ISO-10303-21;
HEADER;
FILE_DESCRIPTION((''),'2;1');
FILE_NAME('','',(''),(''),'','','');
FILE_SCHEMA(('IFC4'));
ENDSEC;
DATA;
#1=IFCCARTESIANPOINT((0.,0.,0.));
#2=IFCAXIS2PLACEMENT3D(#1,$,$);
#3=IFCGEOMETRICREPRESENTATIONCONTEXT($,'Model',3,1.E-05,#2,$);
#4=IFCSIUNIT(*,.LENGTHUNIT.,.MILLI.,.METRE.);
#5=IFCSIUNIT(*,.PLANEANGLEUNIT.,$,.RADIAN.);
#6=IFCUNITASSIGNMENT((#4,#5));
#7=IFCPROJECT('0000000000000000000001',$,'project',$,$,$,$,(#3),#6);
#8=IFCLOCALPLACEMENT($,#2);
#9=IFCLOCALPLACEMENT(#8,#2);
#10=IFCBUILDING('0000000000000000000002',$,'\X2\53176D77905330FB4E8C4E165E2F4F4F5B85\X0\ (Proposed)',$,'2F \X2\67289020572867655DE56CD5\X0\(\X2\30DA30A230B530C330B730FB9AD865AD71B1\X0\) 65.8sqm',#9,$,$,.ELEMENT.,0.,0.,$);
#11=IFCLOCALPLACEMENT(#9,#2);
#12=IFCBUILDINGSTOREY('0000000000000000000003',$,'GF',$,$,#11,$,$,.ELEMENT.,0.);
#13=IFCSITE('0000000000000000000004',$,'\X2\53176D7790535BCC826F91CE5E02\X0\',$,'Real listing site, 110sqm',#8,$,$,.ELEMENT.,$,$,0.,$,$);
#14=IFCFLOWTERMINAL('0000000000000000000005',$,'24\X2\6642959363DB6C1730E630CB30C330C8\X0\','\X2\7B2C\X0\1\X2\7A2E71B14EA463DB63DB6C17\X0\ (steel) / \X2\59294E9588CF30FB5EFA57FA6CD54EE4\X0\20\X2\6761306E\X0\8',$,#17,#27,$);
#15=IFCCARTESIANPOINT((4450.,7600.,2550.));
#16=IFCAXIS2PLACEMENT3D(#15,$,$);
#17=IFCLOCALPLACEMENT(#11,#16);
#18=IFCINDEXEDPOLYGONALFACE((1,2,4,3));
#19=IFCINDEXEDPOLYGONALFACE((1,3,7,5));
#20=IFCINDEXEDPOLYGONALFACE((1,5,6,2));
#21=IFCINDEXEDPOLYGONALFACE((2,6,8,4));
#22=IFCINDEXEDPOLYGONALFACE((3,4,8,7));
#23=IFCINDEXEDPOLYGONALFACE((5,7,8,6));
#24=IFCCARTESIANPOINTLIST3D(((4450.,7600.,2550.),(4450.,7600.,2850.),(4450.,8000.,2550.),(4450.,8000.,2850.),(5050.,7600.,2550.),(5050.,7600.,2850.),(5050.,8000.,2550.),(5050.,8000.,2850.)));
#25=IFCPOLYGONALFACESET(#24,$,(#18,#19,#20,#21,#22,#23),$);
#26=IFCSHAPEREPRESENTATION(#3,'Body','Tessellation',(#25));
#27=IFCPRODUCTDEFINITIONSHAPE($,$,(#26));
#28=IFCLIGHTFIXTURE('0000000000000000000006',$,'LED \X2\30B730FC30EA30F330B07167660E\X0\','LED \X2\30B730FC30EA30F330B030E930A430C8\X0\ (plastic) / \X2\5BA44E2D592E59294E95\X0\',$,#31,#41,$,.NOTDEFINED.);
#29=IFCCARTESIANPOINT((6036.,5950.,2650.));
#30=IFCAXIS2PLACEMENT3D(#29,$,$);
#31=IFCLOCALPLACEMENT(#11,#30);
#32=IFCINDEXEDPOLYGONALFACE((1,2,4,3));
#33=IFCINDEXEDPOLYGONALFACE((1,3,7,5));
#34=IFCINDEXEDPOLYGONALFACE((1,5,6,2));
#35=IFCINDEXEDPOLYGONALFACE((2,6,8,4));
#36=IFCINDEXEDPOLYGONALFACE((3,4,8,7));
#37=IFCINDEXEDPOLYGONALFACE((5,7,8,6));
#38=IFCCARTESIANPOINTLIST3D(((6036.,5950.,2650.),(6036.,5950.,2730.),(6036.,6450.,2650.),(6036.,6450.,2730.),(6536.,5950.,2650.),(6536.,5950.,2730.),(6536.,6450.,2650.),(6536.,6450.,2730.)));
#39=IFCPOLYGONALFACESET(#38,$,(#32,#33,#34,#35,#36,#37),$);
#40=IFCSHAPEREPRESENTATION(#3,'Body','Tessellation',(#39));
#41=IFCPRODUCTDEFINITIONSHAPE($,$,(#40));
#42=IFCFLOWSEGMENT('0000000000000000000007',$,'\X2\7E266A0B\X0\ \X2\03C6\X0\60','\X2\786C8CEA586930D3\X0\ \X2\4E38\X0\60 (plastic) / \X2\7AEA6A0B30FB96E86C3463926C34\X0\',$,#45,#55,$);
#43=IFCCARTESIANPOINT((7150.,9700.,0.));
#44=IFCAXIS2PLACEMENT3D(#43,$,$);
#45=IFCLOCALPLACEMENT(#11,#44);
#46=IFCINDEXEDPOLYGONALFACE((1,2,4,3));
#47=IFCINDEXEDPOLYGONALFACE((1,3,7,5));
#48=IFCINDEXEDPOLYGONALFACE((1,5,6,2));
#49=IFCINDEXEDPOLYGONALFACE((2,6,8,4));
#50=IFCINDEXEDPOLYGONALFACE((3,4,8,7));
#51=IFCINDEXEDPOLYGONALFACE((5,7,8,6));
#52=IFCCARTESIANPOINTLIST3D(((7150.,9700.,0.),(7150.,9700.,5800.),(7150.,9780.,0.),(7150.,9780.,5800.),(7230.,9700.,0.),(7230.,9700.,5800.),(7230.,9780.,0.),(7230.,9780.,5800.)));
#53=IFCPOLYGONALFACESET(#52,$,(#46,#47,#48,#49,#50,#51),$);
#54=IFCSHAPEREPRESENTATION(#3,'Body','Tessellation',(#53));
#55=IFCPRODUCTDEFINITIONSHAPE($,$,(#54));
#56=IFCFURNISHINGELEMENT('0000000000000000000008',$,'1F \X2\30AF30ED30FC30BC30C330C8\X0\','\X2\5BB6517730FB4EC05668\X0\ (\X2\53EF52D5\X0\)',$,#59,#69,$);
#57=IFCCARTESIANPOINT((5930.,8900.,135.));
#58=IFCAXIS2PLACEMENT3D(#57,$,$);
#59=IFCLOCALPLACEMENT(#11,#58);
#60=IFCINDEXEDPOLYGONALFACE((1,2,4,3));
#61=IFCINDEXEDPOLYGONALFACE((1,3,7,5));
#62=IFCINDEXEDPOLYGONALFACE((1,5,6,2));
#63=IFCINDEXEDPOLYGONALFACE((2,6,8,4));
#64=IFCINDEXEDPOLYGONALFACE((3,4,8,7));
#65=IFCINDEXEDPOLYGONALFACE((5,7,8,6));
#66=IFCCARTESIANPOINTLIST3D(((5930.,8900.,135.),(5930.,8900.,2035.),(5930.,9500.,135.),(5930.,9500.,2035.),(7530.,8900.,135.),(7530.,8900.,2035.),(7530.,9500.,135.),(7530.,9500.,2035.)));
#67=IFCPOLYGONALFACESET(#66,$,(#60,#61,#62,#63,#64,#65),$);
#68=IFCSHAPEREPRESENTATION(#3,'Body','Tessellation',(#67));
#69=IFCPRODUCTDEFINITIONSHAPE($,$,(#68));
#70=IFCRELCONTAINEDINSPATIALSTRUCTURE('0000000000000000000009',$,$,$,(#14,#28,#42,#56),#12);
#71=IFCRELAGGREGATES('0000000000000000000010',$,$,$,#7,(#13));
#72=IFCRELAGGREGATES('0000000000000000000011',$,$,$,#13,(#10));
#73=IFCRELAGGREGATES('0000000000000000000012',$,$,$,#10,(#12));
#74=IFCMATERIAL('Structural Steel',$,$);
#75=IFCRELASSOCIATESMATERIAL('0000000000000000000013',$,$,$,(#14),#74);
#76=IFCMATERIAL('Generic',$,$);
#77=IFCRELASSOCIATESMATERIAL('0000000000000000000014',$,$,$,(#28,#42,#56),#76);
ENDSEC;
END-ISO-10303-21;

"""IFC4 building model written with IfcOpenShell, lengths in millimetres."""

from ifc_helpers import new_model, si_unit, frame, frame_2d, origin, place, context, project, spatial, rectangle, extrude, material, element, save


model = new_model("IFC4")

# Units and contexts
model_context = context("Model", 3, precision=1e-05, world=origin())
ifc_project = project(units=[si_unit("LENGTHUNIT", "METRE", prefix="MILLI"), si_unit("PLANEANGLEUNIT", "RADIAN")], contexts=[model_context])

# Site, building, storey
site_placement = place(None, origin())
site = spatial("IfcSite", under=ifc_project, at=site_placement, Name="北海道富良野市", ObjectType="Real listing site, 110sqm", CompositionType="ELEMENT", RefElevation=0.0)
building_placement = place(site_placement, origin())
building = spatial("IfcBuilding", under=site, at=building_placement, Name="北海道・二世帯住宅 (Proposed)", ObjectType="2F 木造在来工法(ペアサッシ・高断熱) 65.8sqm", CompositionType="ELEMENT", ElevationOfRefHeight=0.0, ElevationOfTerrain=0.0)
storey_placement = place(building_placement, origin())
storey = spatial("IfcBuildingStorey", under=building, at=storey_placement, Name="GF", CompositionType="ELEMENT", Elevation=0.0)

# Shared definitions
ifc_material_1 = material(Name="Generic")

# Flow terminal
ifc_material_2 = material(Name="Structural Steel")
flow_terminal_placement = place(storey_placement, frame((4450.0, 7600.0, 2550.0)))
element("IfcFlowTerminal", 1, at=flow_terminal_placement, inside=storey, material=ifc_material_2, Name="24時間換気ユニット", Description="第1種熱交換換気 (steel) / 天井裏・建基法令20条の8", context=model_context, shape_type="SweptSolid", body=[
    extrude(rectangle(XDim=600.0, YDim=400.0, at=frame_2d((300.0, 200.0))), frame((4450.0, 7600.0, 2550.0)), (0.0, 0.0, 1.0), 300.0),
])

# Light fixture
light_fixture_placement = place(storey_placement, frame((6036.0, 5950.0, 2650.0)))
element("IfcLightFixture", 2, at=light_fixture_placement, inside=storey, material=ifc_material_1, Name="LED シーリング照明", Description="LED シーリングライト (plastic) / 室中央天井", PredefinedType="NOTDEFINED", context=model_context, shape_type="SweptSolid", body=[
    extrude(rectangle(XDim=500.0, YDim=500.0, at=frame_2d((250.0, 250.0))), frame((6036.0, 5950.0, 2650.0)), (0.0, 0.0, 1.0), 80.0),
])

# Flow segment
flow_segment_placement = place(storey_placement, frame((7150.0, 9700.0, 0.0)))
element("IfcFlowSegment", 3, at=flow_segment_placement, inside=storey, material=ifc_material_1, Name="縦樋 φ60", Description="硬質塩ビ 丸60 (plastic) / 竪樋・雨水排水", context=model_context, shape_type="SweptSolid", body=[
    extrude(rectangle(XDim=80.0, YDim=80.0, at=frame_2d((40.0, 40.0))), frame((7150.0, 9700.0, 0.0)), (0.0, 0.0, 1.0), 5800.0),
])

# Furnishing element
furnishing_placement = place(storey_placement, frame((5930.0, 8900.0, 135.0)))
element("IfcFurnishingElement", 4, at=furnishing_placement, inside=storey, material=ifc_material_1, Name="1F クローゼット", Description="家具・什器 (可動)", context=model_context, shape_type="SweptSolid", body=[
    extrude(rectangle(XDim=1600.0, YDim=600.0, at=frame_2d((800.0, 300.0))), frame((5930.0, 8900.0, 135.0)), (0.0, 0.0, 1.0), 1900.0),
])

save(model, "model.ifc")
